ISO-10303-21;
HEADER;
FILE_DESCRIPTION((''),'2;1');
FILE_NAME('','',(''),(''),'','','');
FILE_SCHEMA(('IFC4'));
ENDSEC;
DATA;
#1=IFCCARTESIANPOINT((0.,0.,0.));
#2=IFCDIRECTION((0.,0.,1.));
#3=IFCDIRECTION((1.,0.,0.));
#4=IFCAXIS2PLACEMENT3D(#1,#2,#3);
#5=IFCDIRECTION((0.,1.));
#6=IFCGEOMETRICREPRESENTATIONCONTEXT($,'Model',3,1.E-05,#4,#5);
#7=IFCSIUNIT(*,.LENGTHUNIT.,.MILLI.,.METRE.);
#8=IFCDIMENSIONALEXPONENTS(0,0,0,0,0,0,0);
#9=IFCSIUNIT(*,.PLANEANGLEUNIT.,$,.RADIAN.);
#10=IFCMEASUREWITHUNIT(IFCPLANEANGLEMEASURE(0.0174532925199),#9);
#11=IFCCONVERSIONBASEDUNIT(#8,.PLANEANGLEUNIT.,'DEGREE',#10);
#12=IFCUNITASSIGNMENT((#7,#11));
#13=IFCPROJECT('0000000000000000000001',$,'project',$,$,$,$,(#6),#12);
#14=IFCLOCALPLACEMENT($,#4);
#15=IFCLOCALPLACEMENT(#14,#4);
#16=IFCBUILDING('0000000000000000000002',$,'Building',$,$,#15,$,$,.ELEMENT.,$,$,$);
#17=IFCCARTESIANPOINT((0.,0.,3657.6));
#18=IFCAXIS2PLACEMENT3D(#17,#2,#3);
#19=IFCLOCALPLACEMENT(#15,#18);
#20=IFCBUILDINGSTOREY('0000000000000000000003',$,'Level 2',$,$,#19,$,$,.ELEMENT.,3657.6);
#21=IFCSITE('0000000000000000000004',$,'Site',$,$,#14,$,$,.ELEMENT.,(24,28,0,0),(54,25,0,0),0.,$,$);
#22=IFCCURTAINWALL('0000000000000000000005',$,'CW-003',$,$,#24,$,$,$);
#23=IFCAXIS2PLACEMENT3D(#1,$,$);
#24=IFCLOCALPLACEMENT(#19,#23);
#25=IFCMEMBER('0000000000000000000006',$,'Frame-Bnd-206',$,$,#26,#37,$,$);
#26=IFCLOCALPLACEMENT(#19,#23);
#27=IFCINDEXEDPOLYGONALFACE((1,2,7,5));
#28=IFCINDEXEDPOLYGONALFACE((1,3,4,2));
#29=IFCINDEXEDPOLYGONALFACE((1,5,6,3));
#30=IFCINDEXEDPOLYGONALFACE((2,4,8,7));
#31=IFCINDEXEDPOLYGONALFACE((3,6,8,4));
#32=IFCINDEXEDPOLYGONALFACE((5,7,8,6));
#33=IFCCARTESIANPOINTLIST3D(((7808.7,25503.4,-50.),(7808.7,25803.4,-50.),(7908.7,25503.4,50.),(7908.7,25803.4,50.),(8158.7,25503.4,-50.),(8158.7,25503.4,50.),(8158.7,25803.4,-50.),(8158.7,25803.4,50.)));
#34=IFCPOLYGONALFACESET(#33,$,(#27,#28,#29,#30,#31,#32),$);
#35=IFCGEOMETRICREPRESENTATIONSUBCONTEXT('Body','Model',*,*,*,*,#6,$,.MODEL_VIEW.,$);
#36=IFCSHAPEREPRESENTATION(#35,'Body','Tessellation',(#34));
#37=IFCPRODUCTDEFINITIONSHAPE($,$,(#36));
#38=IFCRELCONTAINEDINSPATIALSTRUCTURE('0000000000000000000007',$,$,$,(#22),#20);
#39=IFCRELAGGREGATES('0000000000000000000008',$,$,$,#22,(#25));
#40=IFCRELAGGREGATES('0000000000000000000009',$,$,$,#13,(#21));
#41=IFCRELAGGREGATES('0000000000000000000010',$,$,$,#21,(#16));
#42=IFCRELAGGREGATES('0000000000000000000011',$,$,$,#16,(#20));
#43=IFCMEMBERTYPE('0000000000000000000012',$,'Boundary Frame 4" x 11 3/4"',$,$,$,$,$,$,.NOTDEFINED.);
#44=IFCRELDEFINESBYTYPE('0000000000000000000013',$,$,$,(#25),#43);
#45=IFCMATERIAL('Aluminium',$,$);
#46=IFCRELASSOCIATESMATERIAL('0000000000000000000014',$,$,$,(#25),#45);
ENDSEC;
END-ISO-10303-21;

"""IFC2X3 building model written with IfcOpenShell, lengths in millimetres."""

from ifc_helpers import new_model, entity, si_unit, converted_unit, direction, frame, origin_with_axes, place, context, subcontext, project, spatial, polyline, outline, extrude, clip, halfspace, material, type_object, element, aggregate, save


model = new_model("IFC2X3")

# Units and contexts
model_context = context("Model", 3, precision=1e-05, world=origin_with_axes(), true_north=direction((0.0, 1.0)))
body_context = subcontext(model_context, "Body", "Model", "MODEL_VIEW")
ifc_project = project(units=[si_unit("LENGTHUNIT", "METRE", prefix="MILLI"), converted_unit("PLANEANGLEUNIT", "DEGREE", entity("IfcPlaneAngleMeasure", 0.0174532925199), si_unit("PLANEANGLEUNIT", "RADIAN"), dimensions=[0, 0, 0, 0, 0, 0, 0])], contexts=[model_context])

# Site, building, storey
site_placement = place(None, origin_with_axes())
site = spatial("IfcSite", under=ifc_project, at=site_placement, Name="Site", CompositionType="ELEMENT", RefLatitude=(24, 28, 0, 0), RefLongitude=(54, 25, 0, 0), RefElevation=0.0)
building_placement = place(site_placement, origin_with_axes())
building = spatial("IfcBuilding", under=site, at=building_placement, Name="Building", CompositionType="ELEMENT")
storey_placement = place(building_placement, frame((0.0, 0.0, 3657.6), z_axis=(0.0, 0.0, 1.0), x_axis=(1.0, 0.0, 0.0)))
storey = spatial("IfcBuildingStorey", under=building, at=storey_placement, Name="Level 2", CompositionType="ELEMENT", Elevation=3657.6)

# Curtain wall, member
curtain_wall_placement = place(storey_placement, frame((8008.7, 25753.4, 0.0), z_axis=(0.0, 0.0, 1.0), x_axis=(1.0, 0.0, 0.0)))
curtain_wall = element("IfcCurtainWall", 1, at=curtain_wall_placement, inside=storey, Name="CW-003")
ifc_material_1 = material(Name="Aluminium")
member_type_1 = type_object("IfcMemberType", Name="Boundary Frame 4\" x 11 3/4\"", PredefinedType="NOTDEFINED")
member_1_placement = place(curtain_wall_placement, frame((-150.0, 0.0, 0.0), z_axis=(1.0, 0.0, 0.0), x_axis=(0.0, 0.0, 1.0)))
member_1 = element("IfcMember", 2, at=member_1_placement, type_object=member_type_1, material=ifc_material_1, Name="Frame-Bnd-206", context=body_context, shape_type="Clipping", body=[
    clip(extrude(outline(polyline([(250.0, -50.0), (250.0, 50.0), (-50.0, 50.0), (-50.0, -50.0), (250.0, -50.0)])), frame((0.0, 0.0, -50.0), z_axis=(0.0, 0.0, 1.0), x_axis=(0.0, 1.0, 0.0)), (0.0, 0.0, 1.0), 350.0), halfspace(frame((0.0, 0.0, 0.0), z_axis=(-0.707107, 0.0, 0.707107), x_axis=(0.0, -1.0, 0.0)), True)),
])
aggregate(curtain_wall, [member_1])

save(model, "model.ifc")
